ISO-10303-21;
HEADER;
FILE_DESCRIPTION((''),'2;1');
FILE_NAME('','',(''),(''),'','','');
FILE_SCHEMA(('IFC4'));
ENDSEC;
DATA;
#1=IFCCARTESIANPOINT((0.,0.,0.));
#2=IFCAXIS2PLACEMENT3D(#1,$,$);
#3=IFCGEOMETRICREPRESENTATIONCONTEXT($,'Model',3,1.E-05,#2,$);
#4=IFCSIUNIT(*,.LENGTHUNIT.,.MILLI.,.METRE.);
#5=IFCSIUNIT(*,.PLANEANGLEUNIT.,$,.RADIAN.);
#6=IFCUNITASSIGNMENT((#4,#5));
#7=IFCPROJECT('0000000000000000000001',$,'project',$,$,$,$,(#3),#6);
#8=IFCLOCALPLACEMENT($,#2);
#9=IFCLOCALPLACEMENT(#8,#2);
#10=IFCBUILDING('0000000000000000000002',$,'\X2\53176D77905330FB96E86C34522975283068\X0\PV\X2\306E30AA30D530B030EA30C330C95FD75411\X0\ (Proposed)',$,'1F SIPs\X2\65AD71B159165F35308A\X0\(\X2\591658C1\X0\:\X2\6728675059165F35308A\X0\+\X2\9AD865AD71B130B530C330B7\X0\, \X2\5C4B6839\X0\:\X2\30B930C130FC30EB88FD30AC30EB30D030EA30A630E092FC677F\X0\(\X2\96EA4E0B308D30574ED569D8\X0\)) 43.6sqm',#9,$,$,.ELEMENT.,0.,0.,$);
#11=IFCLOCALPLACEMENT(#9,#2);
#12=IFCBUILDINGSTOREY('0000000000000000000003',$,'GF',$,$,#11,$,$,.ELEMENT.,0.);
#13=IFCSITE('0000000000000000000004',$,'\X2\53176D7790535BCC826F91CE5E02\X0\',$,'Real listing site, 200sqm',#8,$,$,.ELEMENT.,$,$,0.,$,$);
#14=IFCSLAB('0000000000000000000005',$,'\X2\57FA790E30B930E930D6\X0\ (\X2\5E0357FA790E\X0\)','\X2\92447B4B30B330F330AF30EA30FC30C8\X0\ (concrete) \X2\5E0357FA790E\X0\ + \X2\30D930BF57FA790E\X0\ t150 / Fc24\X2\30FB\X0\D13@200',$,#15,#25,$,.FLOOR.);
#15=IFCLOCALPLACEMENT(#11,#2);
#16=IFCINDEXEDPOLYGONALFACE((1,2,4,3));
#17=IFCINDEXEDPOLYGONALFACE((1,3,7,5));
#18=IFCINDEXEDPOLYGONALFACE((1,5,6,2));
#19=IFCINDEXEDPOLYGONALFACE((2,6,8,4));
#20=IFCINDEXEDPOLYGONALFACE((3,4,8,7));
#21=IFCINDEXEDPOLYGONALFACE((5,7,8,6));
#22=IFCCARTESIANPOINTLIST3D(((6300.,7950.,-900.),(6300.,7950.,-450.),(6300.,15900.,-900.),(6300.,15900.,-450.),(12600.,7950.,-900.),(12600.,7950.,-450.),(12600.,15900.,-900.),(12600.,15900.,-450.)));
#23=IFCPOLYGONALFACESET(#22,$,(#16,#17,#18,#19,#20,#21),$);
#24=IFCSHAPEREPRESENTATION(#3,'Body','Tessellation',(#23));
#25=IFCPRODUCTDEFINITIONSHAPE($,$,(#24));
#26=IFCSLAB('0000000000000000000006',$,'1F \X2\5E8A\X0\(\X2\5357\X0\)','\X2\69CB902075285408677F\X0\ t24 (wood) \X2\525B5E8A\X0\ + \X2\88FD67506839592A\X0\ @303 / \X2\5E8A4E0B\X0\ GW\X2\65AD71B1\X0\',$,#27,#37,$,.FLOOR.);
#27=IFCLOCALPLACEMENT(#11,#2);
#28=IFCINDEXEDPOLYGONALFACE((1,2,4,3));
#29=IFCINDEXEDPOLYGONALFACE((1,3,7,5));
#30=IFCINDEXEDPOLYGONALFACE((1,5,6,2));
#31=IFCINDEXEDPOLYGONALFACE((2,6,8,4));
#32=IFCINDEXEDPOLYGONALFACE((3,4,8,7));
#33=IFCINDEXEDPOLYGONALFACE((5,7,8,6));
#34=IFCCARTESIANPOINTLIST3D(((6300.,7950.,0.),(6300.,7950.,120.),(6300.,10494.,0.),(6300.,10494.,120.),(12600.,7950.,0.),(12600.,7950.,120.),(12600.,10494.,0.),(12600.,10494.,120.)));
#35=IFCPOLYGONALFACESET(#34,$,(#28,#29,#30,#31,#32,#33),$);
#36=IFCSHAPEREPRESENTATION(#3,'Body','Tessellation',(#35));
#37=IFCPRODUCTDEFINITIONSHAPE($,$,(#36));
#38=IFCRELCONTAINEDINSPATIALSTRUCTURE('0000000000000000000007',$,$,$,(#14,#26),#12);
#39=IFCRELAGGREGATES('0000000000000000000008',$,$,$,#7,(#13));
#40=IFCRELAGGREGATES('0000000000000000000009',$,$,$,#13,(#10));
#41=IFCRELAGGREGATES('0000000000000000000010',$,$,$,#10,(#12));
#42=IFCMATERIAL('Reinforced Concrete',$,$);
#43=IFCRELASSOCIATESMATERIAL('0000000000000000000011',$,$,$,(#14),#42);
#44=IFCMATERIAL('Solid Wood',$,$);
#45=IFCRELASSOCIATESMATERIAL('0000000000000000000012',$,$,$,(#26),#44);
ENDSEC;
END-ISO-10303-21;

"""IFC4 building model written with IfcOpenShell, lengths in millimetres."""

from ifc_helpers import new_model, si_unit, frame, frame_2d, origin, place, context, project, spatial, rectangle, extrude, material, element, save


model = new_model("IFC4")

# Units and contexts
model_context = context("Model", 3, precision=1e-05, world=origin())
ifc_project = project(units=[si_unit("LENGTHUNIT", "METRE", prefix="MILLI"), si_unit("PLANEANGLEUNIT", "RADIAN")], contexts=[model_context])

# Site, building, storey
site_placement = place(None, origin())
site = spatial("IfcSite", under=ifc_project, at=site_placement, Name="北海道富良野市", ObjectType="Real listing site, 200sqm", CompositionType="ELEMENT", RefElevation=0.0)
building_placement = place(site_placement, origin())
building = spatial("IfcBuilding", under=site, at=building_placement, Name="北海道・雨水利用とPVのオフグリッド志向 (Proposed)", ObjectType="1F SIPs断熱外張り(外壁:木材外張り+高断熱サッシ, 屋根:スチール製ガルバリウム鋼板(雪下ろし仕様)) 43.6sqm", CompositionType="ELEMENT", ElevationOfRefHeight=0.0, ElevationOfTerrain=0.0)
storey_placement = place(building_placement, origin())
storey = spatial("IfcBuildingStorey", under=building, at=storey_placement, Name="GF", CompositionType="ELEMENT", Elevation=0.0)

# Shared definitions
ifc_material_1 = material(Name="Solid Wood")

# Slabs
ifc_material_2 = material(Name="Reinforced Concrete")
slab_1_placement = place(storey_placement, frame((3150.0, 3975.0, -450.0)))
element("IfcSlab", 1, at=slab_1_placement, inside=storey, material=ifc_material_2, Name="基礎スラブ (布基礎)", Description="鉄筋コンクリート (concrete) 布基礎 + ベタ基礎 t150 / Fc24・D13@200", PredefinedType="FLOOR", context=model_context, shape_type="SweptSolid", body=[
    extrude(rectangle(XDim=6300.0, YDim=7950.0, at=frame_2d((3150.0, 3975.0))), frame((3150.0, 3975.0, -450.0)), (0.0, 0.0, 1.0), 450.0),
])
slab_2_placement = place(storey_placement, frame((3150.0, 3975.0, 0.0)))
element("IfcSlab", 2, at=slab_2_placement, inside=storey, material=ifc_material_1, Name="1F 床(南)", Description="構造用合板 t24 (wood) 剛床 + 製材根太 @303 / 床下 GW断熱", PredefinedType="FLOOR", context=model_context, shape_type="SweptSolid", body=[
    extrude(rectangle(XDim=6300.0, YDim=2544.0, at=frame_2d((3150.0, 1272.0))), frame((3150.0, 3975.0, 0.0)), (0.0, 0.0, 1.0), 120.0),
])

save(model, "model.ifc")
